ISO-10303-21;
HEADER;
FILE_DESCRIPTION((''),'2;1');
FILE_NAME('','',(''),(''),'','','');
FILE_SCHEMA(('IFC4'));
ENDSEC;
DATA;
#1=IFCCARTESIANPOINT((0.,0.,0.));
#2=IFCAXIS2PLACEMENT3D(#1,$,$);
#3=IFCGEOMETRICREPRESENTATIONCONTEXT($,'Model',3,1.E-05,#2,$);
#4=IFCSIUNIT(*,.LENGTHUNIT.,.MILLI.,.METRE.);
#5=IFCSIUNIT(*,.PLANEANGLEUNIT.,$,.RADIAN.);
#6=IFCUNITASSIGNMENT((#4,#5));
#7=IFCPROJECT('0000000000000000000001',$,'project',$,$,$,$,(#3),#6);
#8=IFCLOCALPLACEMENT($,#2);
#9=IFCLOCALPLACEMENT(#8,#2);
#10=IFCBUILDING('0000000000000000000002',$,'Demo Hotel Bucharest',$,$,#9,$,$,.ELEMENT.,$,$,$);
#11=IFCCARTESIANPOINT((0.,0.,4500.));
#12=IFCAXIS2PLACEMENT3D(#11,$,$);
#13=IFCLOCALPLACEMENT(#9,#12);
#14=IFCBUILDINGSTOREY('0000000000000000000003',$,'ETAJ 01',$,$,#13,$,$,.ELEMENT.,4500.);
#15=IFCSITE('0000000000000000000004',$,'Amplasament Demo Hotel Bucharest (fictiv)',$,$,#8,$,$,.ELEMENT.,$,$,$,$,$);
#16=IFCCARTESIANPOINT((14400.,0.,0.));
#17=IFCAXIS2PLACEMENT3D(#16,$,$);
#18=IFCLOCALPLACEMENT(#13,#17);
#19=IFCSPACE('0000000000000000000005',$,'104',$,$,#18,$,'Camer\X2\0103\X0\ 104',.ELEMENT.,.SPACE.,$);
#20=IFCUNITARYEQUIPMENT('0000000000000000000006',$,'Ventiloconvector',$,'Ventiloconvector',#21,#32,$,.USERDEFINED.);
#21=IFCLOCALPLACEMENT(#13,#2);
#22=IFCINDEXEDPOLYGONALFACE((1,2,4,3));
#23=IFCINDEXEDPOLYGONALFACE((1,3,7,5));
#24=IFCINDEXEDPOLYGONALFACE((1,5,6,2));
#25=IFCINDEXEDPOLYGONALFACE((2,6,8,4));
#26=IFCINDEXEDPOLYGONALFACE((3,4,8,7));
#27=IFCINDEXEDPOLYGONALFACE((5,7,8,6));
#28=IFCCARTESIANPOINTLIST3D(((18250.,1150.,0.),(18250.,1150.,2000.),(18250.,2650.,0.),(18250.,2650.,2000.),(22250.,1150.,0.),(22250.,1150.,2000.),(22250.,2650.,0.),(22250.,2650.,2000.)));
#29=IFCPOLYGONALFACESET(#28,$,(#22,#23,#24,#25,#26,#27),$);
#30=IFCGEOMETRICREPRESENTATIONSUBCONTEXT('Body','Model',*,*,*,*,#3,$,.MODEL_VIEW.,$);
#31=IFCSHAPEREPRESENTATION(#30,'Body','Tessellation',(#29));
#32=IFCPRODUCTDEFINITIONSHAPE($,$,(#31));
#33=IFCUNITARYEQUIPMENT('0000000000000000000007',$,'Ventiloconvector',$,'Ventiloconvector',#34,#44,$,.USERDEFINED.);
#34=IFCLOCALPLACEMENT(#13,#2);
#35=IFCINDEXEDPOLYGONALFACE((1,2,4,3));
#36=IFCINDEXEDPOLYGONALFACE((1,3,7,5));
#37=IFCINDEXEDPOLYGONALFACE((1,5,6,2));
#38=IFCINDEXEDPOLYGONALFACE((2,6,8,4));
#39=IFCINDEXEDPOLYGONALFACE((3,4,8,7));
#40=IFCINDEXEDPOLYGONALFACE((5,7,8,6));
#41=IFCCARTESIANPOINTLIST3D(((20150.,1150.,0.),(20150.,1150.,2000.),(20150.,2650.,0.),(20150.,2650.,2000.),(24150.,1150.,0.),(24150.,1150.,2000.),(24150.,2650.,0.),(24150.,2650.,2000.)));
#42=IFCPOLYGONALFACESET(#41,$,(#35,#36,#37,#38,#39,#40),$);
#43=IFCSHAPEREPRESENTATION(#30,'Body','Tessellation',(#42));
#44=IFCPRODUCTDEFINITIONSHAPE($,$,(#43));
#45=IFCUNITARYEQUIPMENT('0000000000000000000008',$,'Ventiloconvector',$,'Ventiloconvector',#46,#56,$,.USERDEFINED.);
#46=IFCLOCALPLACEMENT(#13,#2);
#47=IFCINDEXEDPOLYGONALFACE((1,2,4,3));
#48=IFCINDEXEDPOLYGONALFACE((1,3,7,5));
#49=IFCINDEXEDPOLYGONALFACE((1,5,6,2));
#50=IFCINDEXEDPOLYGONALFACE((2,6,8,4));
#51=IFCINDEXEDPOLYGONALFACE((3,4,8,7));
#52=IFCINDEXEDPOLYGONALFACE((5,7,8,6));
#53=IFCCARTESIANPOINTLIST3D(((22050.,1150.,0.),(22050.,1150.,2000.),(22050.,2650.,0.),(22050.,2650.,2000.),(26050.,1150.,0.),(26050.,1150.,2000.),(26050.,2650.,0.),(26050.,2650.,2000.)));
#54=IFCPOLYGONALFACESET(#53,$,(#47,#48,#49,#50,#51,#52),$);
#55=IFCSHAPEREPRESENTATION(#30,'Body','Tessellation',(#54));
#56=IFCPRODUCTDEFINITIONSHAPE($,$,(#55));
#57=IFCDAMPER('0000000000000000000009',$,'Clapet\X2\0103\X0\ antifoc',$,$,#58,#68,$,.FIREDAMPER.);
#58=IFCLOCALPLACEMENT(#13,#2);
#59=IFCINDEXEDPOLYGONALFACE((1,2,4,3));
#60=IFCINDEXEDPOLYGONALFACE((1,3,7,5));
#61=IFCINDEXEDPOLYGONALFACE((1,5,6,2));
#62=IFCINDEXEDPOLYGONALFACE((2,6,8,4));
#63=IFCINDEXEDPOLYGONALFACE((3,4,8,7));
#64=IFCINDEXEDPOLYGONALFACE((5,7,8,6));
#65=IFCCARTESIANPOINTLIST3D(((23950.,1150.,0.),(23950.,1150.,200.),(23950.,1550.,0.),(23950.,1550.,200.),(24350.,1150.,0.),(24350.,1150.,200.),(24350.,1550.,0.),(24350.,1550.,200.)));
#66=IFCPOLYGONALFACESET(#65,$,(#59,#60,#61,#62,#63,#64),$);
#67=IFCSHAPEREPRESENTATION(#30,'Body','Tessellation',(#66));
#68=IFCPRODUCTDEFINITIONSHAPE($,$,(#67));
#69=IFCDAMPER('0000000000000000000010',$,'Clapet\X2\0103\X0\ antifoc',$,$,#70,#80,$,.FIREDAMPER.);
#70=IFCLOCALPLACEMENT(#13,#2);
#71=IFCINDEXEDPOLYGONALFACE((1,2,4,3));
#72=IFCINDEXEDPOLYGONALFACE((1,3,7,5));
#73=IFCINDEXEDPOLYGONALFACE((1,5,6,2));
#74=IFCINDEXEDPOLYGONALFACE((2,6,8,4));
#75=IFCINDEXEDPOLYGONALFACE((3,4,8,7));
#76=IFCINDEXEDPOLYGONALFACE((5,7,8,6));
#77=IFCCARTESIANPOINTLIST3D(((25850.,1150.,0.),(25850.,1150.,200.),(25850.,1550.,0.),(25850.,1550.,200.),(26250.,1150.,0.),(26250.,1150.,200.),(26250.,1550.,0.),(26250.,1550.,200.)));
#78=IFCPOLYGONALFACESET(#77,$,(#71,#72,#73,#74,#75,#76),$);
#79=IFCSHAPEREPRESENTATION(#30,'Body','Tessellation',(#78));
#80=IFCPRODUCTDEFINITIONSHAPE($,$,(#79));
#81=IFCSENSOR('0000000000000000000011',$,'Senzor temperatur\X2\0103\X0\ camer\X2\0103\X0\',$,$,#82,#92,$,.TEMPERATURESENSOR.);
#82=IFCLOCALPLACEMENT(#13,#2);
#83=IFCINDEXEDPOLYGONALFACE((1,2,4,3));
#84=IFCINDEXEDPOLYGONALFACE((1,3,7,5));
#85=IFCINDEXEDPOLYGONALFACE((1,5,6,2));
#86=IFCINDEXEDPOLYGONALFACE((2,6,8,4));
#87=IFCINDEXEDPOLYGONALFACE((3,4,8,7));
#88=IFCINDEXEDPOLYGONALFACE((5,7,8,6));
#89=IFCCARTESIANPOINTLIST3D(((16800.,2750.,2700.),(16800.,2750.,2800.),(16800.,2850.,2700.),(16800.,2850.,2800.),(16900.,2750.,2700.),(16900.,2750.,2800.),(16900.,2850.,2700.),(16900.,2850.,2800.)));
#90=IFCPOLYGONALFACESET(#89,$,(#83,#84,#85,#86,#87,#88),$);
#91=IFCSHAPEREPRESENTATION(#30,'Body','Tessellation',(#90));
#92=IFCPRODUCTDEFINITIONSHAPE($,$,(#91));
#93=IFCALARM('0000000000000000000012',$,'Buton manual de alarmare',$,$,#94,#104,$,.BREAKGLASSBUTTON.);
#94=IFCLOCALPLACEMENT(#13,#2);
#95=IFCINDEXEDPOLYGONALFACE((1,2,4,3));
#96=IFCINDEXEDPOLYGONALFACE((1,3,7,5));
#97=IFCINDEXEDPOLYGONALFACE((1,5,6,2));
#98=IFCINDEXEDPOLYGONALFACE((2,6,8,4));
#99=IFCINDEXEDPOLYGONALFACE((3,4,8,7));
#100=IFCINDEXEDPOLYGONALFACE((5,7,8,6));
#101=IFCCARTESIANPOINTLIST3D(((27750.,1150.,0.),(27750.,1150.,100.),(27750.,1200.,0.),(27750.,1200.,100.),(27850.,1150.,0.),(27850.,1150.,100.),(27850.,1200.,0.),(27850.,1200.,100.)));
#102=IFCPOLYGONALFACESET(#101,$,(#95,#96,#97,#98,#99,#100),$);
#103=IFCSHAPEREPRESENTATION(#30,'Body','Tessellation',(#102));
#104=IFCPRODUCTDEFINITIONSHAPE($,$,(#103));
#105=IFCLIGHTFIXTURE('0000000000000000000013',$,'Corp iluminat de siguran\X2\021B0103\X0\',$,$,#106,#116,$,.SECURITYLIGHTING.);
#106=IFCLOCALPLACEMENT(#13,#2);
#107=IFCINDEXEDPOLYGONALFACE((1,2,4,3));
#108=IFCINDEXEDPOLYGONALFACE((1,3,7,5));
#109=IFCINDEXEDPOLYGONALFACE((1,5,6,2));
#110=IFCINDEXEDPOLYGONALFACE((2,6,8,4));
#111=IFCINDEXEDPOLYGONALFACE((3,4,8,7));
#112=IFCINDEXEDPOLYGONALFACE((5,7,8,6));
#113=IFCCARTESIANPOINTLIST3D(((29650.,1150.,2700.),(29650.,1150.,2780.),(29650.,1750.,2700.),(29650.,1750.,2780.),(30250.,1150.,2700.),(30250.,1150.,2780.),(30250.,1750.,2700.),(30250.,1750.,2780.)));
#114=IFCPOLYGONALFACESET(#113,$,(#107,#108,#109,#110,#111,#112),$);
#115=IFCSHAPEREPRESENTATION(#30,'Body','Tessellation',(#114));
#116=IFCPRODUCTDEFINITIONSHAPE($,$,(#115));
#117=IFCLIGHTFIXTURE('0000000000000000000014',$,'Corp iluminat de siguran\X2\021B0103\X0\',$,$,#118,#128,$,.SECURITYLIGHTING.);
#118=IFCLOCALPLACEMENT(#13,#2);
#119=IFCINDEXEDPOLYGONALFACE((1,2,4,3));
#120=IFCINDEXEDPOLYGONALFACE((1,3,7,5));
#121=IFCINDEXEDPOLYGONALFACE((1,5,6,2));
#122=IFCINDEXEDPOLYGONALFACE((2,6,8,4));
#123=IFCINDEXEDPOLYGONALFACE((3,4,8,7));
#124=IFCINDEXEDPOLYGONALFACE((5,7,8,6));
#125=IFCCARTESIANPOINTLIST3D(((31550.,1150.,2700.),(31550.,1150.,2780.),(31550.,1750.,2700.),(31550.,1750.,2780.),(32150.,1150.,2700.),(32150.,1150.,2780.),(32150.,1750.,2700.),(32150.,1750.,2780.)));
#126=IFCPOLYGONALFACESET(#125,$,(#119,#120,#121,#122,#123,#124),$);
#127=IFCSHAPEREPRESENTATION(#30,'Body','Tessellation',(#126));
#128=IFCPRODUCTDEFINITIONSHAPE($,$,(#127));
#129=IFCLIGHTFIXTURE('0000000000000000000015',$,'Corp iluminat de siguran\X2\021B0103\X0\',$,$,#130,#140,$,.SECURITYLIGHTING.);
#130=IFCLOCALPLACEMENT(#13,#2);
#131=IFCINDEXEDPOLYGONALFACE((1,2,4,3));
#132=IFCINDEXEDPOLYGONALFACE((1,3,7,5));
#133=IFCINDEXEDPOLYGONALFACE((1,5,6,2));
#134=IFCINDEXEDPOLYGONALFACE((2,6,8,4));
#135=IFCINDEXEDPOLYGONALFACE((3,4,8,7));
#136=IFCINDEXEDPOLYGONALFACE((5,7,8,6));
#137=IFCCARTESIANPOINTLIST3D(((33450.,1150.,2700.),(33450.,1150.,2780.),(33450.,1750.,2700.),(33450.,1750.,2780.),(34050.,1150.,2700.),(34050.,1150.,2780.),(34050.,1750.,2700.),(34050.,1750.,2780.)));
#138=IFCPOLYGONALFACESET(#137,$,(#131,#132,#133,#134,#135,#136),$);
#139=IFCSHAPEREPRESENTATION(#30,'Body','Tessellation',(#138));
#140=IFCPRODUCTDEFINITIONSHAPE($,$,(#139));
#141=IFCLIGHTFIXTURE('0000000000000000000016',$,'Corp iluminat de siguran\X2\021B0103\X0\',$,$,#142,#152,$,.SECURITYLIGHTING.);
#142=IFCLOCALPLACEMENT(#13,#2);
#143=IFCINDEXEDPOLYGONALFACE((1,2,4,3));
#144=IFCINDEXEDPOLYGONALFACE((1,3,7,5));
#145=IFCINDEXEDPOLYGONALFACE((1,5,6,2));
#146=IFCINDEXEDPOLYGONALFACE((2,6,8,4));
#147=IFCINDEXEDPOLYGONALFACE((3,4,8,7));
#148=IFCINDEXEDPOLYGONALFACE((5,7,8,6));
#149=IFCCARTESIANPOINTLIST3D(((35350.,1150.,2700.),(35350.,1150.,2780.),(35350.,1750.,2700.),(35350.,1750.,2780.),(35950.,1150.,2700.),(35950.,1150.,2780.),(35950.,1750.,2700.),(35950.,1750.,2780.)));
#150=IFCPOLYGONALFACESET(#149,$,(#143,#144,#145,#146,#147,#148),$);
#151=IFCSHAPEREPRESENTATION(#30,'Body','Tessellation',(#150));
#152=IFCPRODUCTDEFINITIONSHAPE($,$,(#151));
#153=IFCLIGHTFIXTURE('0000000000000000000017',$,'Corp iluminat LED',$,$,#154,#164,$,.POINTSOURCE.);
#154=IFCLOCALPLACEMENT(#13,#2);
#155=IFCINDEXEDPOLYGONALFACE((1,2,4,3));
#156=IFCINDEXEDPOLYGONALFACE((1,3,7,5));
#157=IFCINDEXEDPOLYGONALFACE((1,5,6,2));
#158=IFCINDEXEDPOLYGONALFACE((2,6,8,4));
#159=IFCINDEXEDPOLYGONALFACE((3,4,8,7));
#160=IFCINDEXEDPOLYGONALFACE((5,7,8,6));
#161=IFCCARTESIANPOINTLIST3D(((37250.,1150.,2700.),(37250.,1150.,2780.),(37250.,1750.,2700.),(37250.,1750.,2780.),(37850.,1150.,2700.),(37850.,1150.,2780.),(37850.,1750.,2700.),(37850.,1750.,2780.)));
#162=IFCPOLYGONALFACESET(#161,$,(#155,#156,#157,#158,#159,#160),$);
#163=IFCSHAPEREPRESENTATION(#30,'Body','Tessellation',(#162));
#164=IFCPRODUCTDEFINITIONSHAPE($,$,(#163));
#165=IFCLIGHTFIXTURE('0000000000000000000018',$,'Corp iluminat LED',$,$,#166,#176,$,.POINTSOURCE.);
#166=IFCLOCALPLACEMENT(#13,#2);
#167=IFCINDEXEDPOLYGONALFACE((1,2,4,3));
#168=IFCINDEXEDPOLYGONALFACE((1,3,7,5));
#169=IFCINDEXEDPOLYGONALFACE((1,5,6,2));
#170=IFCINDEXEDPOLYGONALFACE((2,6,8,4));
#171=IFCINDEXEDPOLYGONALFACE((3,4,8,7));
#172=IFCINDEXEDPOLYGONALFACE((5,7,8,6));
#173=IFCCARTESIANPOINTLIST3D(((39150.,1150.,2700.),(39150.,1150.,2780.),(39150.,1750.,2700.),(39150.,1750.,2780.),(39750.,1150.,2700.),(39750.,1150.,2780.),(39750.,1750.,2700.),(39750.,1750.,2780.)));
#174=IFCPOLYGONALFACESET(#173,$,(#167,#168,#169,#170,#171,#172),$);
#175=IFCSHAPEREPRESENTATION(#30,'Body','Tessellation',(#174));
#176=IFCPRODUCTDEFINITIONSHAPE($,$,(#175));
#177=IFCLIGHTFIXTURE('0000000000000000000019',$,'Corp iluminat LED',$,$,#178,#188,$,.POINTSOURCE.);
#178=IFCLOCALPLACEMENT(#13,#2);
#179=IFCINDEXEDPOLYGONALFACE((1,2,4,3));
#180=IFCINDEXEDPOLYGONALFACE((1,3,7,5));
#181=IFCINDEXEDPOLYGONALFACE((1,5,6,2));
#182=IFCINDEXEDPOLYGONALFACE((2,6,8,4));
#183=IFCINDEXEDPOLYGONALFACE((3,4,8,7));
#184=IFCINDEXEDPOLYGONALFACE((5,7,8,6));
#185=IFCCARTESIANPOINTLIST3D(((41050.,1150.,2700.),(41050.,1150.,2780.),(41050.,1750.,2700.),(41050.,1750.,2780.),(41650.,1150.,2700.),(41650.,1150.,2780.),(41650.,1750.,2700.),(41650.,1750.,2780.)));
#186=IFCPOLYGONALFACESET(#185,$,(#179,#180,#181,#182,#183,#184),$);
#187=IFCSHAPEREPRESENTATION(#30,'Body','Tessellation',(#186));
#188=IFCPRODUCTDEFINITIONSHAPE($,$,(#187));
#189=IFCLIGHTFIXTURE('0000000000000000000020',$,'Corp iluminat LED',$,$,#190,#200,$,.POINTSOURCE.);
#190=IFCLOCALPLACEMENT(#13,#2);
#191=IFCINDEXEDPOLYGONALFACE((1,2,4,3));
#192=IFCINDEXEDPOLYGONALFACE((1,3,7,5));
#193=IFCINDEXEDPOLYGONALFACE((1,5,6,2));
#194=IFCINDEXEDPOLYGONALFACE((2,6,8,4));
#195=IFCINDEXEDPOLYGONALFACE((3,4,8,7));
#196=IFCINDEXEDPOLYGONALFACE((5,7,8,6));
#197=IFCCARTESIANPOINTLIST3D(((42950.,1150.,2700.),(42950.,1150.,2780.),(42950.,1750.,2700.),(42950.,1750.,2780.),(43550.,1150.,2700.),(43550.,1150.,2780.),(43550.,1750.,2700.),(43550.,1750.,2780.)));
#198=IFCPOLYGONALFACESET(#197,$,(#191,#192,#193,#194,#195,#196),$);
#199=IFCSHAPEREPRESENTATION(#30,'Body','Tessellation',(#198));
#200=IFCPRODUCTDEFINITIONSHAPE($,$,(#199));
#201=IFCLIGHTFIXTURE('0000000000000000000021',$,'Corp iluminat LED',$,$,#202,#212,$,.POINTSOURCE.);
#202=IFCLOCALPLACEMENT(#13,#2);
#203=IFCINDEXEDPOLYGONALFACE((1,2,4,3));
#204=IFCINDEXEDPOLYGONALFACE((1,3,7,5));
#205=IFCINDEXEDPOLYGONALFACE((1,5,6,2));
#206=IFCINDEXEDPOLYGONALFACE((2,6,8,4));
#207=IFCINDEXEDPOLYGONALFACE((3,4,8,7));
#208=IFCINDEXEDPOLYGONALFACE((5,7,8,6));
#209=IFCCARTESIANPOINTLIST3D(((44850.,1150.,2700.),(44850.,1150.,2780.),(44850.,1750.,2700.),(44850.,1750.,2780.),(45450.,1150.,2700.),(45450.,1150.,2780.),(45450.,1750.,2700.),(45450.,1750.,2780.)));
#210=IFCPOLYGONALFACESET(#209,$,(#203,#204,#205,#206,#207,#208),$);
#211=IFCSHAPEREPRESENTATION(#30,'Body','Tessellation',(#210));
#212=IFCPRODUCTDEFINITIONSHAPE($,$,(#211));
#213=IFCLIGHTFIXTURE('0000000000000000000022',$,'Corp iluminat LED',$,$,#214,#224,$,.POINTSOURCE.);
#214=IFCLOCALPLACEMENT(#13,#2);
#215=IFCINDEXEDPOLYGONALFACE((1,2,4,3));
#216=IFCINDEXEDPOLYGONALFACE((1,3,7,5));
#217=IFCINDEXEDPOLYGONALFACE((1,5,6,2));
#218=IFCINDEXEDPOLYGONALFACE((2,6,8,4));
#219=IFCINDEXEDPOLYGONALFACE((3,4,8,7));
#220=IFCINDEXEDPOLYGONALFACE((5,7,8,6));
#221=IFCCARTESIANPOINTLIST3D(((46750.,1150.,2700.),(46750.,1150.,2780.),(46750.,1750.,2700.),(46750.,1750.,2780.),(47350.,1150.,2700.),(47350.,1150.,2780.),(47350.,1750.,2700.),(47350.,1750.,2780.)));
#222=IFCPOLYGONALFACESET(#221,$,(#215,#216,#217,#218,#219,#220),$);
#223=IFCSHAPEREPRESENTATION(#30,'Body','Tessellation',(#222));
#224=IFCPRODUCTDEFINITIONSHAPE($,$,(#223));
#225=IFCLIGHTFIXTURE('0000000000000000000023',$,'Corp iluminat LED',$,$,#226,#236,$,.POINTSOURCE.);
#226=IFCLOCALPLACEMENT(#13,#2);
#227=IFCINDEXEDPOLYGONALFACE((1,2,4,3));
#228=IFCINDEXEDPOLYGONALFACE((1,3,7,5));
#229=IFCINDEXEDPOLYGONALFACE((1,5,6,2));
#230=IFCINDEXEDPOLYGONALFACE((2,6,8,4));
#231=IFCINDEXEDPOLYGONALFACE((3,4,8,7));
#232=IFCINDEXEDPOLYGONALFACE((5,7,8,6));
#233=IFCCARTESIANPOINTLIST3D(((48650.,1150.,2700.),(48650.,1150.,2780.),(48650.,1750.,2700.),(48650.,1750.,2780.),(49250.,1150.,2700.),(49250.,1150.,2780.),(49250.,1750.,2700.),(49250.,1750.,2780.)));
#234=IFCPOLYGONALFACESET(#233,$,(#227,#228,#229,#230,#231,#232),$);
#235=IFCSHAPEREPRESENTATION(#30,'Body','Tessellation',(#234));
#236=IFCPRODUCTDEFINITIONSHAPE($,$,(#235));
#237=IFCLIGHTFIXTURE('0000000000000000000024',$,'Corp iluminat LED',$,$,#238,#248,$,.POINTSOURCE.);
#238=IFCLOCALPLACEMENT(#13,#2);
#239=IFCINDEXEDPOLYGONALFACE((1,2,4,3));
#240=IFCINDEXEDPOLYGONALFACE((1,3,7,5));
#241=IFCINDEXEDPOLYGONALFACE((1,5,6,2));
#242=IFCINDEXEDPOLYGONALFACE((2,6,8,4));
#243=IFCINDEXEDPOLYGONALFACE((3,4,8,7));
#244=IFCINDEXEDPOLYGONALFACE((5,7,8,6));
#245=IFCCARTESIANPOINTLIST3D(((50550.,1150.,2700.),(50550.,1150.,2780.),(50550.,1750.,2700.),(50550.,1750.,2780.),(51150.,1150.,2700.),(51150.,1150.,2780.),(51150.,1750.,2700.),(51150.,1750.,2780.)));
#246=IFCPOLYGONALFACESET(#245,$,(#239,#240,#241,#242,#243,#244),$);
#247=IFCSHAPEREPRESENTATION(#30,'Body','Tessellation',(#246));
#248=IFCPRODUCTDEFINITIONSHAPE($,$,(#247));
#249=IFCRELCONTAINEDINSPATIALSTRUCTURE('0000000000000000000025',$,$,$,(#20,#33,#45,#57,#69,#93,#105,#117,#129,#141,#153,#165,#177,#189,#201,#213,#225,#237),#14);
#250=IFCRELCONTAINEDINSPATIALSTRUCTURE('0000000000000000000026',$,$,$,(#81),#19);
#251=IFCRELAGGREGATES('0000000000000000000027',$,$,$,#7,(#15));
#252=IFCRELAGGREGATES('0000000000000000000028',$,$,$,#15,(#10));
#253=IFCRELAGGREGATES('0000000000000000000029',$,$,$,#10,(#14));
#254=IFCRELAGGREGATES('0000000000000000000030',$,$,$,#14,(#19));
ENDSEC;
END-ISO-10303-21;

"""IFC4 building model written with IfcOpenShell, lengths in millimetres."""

from ifc_helpers import new_model, si_unit, frame, frame_2d, origin, place, context, subcontext, project, spatial, rectangle, extrude, element, save


model = new_model("IFC4")

# Units and contexts
model_context = context("Model", 3, precision=1e-05, world=origin())
body_context = subcontext(model_context, "Body", "Model", "MODEL_VIEW")
ifc_project = project(units=[si_unit("LENGTHUNIT", "METRE", prefix="MILLI"), si_unit("PLANEANGLEUNIT", "RADIAN")], contexts=[model_context])

# Site, building, storey
site_placement = place(None, origin())
site = spatial("IfcSite", under=ifc_project, at=site_placement, Name="Amplasament Demo Hotel Bucharest (fictiv)", CompositionType="ELEMENT")
building_placement = place(site_placement, origin())
building = spatial("IfcBuilding", under=site, at=building_placement, Name="Demo Hotel Bucharest", CompositionType="ELEMENT")
storey_placement = place(building_placement, frame((0.0, 0.0, 4500.0)))
storey = spatial("IfcBuildingStorey", under=building, at=storey_placement, Name="ETAJ 01", CompositionType="ELEMENT", Elevation=4500.0)

# Unitary equipment
for number, where, name in (
    (1, (18250.0, 1150.0, 0.0), "Ventiloconvector"),
    (2, (20150.0, 1150.0, 0.0), "Ventiloconvector"),
    (3, (22050.0, 1150.0, 0.0), "Ventiloconvector"),
):
    element("IfcUnitaryEquipment", number, at=place(storey_placement, frame(where)), inside=storey, Name=name, ObjectType="Ventiloconvector", PredefinedType="USERDEFINED", context=body_context, shape_type="SweptSolid", body=[
        extrude(rectangle(XDim=4000.0, YDim=1500.0, at=frame_2d((2000.0, 750.0))), origin(), (0.0, 0.0, 1.0), 2000.0),
    ])

# Dampers
for number, where, name in (
    (4, (23950.0, 1150.0, 0.0), "Clapetă antifoc"),
    (5, (25850.0, 1150.0, 0.0), "Clapetă antifoc"),
):
    element("IfcDamper", number, at=place(storey_placement, frame(where)), inside=storey, Name=name, PredefinedType="FIREDAMPER", context=body_context, shape_type="SweptSolid", body=[
        extrude(rectangle(XDim=400.0, YDim=400.0, at=frame_2d((200.0, 200.0))), origin(), (0.0, 0.0, 1.0), 200.0),
    ])

# Shared definitions
space_placement = place(storey_placement, frame((14400.0, 0.0, 0.0)))
space = spatial("IfcSpace", under=storey, at=space_placement, Name="104", LongName="Cameră 104", CompositionType="ELEMENT", PredefinedType="SPACE")

# Sensor
sensor_placement = place(storey_placement, frame((16800.0, 2750.0, 2700.0)))
element("IfcSensor", 6, at=sensor_placement, inside=space, Name="Senzor temperatură cameră", PredefinedType="TEMPERATURESENSOR", context=body_context, shape_type="SweptSolid", body=[
    extrude(rectangle(XDim=100.0, YDim=100.0, at=frame_2d((50.0, 50.0))), origin(), (0.0, 0.0, 1.0), 100.0),
])

# Alarm
alarm_placement = place(storey_placement, frame((27750.0, 1150.0, 0.0)))
element("IfcAlarm", 7, at=alarm_placement, inside=storey, Name="Buton manual de alarmare", PredefinedType="BREAKGLASSBUTTON", context=body_context, shape_type="SweptSolid", body=[
    extrude(rectangle(XDim=100.0, YDim=50.0, at=frame_2d((50.0, 25.0))), origin(), (0.0, 0.0, 1.0), 100.0),
])

# Light fixtures
for number, where, name in (
    (8, (29650.0, 1150.0, 2700.0), "Corp iluminat de siguranță"),
    (9, (31550.0, 1150.0, 2700.0), "Corp iluminat de siguranță"),
    (10, (33450.0, 1150.0, 2700.0), "Corp iluminat de siguranță"),
    (11, (35350.0, 1150.0, 2700.0), "Corp iluminat de siguranță"),
):
    element("IfcLightFixture", number, at=place(storey_placement, frame(where)), inside=storey, Name=name, PredefinedType="SECURITYLIGHTING", context=body_context, shape_type="SweptSolid", body=[
        extrude(rectangle(XDim=600.0, YDim=600.0, at=frame_2d((300.0, 300.0))), origin(), (0.0, 0.0, 1.0), 80.0),
    ])
for number, where, name in (
    (12, (37250.0, 1150.0, 2700.0), "Corp iluminat LED"),
    (13, (39150.0, 1150.0, 2700.0), "Corp iluminat LED"),
    (14, (41050.0, 1150.0, 2700.0), "Corp iluminat LED"),
    (15, (42950.0, 1150.0, 2700.0), "Corp iluminat LED"),
    (16, (44850.0, 1150.0, 2700.0), "Corp iluminat LED"),
    (17, (46750.0, 1150.0, 2700.0), "Corp iluminat LED"),
    (18, (48650.0, 1150.0, 2700.0), "Corp iluminat LED"),
    (19, (50550.0, 1150.0, 2700.0), "Corp iluminat LED"),
):
    element("IfcLightFixture", number, at=place(storey_placement, frame(where)), inside=storey, Name=name, PredefinedType="POINTSOURCE", context=body_context, shape_type="SweptSolid", body=[
        extrude(rectangle(XDim=600.0, YDim=600.0, at=frame_2d((300.0, 300.0))), origin(), (0.0, 0.0, 1.0), 80.0),
    ])

save(model, "model.ifc")
